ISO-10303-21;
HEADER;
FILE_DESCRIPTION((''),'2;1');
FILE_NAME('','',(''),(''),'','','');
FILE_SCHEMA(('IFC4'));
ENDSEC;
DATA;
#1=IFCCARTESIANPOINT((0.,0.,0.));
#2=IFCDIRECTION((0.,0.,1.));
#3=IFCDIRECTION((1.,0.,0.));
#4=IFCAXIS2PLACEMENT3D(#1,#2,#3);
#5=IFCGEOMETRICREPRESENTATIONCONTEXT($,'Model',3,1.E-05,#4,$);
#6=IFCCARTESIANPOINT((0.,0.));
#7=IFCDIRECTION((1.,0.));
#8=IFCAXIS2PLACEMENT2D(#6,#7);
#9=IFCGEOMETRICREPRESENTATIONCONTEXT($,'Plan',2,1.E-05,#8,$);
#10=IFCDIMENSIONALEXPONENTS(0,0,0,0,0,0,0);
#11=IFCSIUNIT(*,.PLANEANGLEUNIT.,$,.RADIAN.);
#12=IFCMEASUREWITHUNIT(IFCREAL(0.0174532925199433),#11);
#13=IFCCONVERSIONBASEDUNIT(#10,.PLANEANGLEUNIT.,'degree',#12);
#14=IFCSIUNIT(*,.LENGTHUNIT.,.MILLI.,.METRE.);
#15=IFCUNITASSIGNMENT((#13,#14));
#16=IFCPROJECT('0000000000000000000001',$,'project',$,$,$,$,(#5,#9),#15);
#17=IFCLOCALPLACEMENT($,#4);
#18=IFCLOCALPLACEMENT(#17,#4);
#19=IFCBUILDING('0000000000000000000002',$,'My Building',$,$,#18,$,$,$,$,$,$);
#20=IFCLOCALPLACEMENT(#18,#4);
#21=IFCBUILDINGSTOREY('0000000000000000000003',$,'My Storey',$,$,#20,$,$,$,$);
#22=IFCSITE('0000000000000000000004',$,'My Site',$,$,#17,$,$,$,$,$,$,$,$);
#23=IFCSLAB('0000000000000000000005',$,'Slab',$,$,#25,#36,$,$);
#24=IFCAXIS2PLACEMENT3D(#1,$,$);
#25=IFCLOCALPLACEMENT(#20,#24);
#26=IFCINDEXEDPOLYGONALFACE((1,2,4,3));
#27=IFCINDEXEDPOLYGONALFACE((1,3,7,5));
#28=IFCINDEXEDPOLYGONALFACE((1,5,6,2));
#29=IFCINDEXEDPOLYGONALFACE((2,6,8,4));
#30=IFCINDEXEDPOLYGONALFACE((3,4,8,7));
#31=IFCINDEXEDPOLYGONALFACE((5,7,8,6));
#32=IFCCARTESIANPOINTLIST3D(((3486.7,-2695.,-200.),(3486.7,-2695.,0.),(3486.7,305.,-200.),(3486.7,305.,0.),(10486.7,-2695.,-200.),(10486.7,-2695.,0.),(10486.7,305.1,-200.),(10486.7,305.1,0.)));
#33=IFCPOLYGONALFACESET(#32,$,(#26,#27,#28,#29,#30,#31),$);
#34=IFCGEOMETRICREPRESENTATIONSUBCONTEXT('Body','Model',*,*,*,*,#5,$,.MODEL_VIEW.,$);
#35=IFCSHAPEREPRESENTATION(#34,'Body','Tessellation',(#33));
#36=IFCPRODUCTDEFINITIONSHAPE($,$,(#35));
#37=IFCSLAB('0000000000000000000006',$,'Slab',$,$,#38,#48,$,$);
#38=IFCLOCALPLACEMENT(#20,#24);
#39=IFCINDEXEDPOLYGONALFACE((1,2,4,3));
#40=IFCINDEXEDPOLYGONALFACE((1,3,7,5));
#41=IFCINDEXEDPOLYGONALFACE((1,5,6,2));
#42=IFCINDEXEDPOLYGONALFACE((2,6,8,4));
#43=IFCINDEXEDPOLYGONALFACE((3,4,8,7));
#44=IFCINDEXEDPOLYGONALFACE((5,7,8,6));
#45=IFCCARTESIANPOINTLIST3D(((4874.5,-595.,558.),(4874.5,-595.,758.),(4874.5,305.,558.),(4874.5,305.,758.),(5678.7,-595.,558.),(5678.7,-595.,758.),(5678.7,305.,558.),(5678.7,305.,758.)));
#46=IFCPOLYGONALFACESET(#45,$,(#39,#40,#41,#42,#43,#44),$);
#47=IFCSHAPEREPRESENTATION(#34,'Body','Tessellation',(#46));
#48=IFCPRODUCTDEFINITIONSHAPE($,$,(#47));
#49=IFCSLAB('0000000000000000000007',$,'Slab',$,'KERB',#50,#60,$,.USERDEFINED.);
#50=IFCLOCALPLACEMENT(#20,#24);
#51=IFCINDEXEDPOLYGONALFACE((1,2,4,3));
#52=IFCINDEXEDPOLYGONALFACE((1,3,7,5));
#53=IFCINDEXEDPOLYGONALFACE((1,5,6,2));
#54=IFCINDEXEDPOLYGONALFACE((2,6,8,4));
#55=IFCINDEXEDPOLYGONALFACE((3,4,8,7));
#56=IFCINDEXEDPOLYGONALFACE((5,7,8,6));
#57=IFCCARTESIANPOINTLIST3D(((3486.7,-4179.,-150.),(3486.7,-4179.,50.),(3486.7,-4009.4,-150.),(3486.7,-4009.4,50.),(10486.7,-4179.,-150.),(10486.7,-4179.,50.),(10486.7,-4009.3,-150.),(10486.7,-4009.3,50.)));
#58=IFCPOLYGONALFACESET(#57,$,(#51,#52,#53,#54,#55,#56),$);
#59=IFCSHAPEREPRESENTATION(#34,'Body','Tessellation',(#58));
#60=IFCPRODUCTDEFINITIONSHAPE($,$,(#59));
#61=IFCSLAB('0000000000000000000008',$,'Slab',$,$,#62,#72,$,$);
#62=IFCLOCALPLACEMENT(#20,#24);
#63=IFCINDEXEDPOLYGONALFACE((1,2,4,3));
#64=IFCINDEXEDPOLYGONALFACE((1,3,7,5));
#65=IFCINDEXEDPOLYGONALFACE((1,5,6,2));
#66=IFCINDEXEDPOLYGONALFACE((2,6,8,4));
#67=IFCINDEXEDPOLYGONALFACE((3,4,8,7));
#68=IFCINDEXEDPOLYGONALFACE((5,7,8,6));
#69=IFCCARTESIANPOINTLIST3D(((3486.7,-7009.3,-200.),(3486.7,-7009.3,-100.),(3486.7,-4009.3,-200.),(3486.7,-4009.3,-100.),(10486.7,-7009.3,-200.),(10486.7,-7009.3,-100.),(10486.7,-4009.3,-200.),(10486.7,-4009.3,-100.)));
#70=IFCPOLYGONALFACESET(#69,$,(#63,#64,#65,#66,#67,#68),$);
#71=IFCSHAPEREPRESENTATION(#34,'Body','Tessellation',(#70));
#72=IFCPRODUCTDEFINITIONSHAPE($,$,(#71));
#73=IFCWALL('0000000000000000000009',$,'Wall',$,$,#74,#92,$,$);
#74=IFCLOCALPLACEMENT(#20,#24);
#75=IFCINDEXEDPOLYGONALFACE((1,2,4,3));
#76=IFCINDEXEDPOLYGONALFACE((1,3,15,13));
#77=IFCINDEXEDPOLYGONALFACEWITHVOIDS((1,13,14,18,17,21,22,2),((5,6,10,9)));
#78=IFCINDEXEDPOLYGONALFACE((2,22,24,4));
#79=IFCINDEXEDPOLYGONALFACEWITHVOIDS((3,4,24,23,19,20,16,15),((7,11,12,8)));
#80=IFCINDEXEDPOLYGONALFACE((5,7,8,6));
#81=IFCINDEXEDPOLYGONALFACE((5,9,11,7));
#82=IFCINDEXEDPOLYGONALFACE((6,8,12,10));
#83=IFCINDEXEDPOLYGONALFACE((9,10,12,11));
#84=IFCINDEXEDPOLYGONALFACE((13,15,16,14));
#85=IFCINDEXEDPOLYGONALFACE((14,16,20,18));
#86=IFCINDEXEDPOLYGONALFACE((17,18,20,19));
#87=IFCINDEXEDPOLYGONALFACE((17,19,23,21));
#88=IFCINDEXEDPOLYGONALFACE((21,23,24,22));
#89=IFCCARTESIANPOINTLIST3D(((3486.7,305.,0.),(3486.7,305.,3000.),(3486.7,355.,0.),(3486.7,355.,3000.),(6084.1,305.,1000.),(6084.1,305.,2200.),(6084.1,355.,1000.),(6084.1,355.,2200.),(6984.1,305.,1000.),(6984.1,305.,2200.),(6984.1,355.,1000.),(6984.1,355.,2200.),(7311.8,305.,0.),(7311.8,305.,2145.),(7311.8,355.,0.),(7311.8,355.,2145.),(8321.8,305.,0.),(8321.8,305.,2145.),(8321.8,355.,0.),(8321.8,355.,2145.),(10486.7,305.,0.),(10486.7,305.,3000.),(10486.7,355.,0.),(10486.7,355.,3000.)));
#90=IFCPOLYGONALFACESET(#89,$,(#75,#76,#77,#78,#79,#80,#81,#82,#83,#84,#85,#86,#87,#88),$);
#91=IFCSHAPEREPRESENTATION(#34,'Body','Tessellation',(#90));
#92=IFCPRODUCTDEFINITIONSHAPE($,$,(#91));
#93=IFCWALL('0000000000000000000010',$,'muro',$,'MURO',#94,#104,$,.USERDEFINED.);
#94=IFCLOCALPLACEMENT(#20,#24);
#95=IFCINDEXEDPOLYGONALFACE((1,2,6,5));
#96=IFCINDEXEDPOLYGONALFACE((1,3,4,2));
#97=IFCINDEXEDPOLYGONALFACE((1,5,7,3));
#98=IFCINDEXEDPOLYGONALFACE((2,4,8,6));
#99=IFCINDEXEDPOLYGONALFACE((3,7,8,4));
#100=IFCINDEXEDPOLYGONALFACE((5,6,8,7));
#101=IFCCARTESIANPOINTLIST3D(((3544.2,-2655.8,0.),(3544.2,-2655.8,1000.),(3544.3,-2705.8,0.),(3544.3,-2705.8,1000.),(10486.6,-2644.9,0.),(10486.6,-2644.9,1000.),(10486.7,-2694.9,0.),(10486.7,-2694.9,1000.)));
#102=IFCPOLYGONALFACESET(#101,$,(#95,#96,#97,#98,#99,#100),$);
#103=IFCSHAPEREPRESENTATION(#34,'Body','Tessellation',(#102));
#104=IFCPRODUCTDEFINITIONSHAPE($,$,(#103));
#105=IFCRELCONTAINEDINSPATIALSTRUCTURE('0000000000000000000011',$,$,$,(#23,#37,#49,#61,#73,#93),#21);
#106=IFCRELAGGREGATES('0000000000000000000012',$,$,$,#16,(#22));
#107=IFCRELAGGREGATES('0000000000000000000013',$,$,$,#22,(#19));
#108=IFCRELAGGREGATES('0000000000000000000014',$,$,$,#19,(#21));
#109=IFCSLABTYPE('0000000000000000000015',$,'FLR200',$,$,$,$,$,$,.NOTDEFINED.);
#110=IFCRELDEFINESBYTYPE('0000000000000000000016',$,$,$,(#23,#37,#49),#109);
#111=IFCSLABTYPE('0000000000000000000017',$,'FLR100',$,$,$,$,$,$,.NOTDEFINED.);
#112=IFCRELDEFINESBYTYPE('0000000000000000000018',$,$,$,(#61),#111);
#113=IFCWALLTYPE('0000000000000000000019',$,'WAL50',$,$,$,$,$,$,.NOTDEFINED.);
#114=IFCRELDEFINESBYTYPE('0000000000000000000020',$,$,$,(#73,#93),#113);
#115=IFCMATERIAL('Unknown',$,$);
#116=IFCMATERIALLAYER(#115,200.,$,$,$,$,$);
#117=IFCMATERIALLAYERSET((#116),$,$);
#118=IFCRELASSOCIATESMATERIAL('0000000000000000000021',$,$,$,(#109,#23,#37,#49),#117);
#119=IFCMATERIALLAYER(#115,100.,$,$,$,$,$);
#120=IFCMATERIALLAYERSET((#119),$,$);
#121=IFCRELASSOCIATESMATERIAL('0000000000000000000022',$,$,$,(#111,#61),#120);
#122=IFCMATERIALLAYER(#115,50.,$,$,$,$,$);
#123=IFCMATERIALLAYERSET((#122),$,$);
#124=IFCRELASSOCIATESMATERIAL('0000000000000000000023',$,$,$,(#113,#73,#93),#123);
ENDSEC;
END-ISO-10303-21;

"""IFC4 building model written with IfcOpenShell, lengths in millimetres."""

from ifc_helpers import new_model, entity, si_unit, converted_unit, frame, origin_with_axes, origin_2d_with_axis, place, context, subcontext, project, spatial, line, indexed_curve, outline, extrude, source, transform, mapped, material, layer, layer_set, layer_usage, type_object, element, save


model = new_model("IFC4")

# Units and contexts
model_context = context("Model", 3, precision=1e-05, world=origin_with_axes())
plan_context = context("Plan", 2, precision=1e-05, world=origin_2d_with_axis())
body_context = subcontext(model_context, "Body", "Model", "MODEL_VIEW")
ifc_project = project(units=[converted_unit("PLANEANGLEUNIT", "degree", entity("IfcReal", 0.0174532925199433), si_unit("PLANEANGLEUNIT", "RADIAN"), dimensions=[0, 0, 0, 0, 0, 0, 0]), si_unit("LENGTHUNIT", "METRE", prefix="MILLI")], contexts=[model_context, plan_context])

# Site, building, storey
site_placement = place(None, origin_with_axes())
site = spatial("IfcSite", under=ifc_project, at=site_placement, Name="My Site")
building_placement = place(site_placement, origin_with_axes())
building = spatial("IfcBuilding", under=site, at=building_placement, Name="My Building")
storey_placement = place(building_placement, origin_with_axes())
storey = spatial("IfcBuildingStorey", under=building, at=storey_placement, Name="My Storey")

# Slabs
ifc_material = material(Name="Unknown")
ifc_layer_1 = layer(ifc_material, 200.0)
ifc_layer_set_1 = layer_set([ifc_layer_1])
ifc_layer_usage_1 = layer_usage(ifc_layer_set_1, "AXIS3", "POSITIVE", -200.0)
slab_type_1 = type_object("IfcSlabType", Name="FLR200", PredefinedType="NOTDEFINED", material=ifc_layer_set_1)
slab_1_placement = place(storey_placement, frame((3486.7, 305.0, 0.0), z_axis=(0.0, 0.0, 1.0), x_axis=(1.0, 0.0, 0.0)))
element("IfcSlab", 1, at=slab_1_placement, inside=storey, type_object=slab_type_1, material=ifc_layer_usage_1, Name="Slab", context=body_context, shape_type="SweptSolid", body=[
    extrude(outline(indexed_curve([(0.0, 0.0), (0.0, -3000.0), (7000.0, -3000.0), (7000.0, 0.0), (0.0, 0.0)])), frame((0.0, 0.0, -200.0), z_axis=(0.0, 0.0, 1.0), x_axis=(1.0, 0.0, 0.0)), (0.0, 0.0, 1.0), 200.0),
])
ifc_layer_usage_2 = layer_usage(ifc_layer_set_1, "AXIS3", "POSITIVE", -200.0)
slab_2_placement = place(storey_placement, frame((4874.5, -595.0, 758.0), z_axis=(0.0, 0.0, 1.0), x_axis=(1.0, 0.0, 0.0)))
element("IfcSlab", 2, at=slab_2_placement, inside=storey, type_object=slab_type_1, material=ifc_layer_usage_2, Name="Slab", context=body_context, shape_type="SweptSolid", body=[
    extrude(outline(indexed_curve([(0.0, 0.0), (804.2, 0.0), (804.2, 900.0), (0.0, 900.0), (0.0, 0.0)])), frame((0.0, 0.0, -200.0), z_axis=(0.0, 0.0, 1.0), x_axis=(1.0, 0.0, 0.0)), (0.0, 0.0, 1.0), 200.0),
])
ifc_layer_usage_3 = layer_usage(ifc_layer_set_1, "AXIS3", "POSITIVE", -200.0)
slab_3_placement = place(storey_placement, frame((3486.7, -4009.4, 50.0), z_axis=(0.0, 0.0, 1.0), x_axis=(1.0, 0.0, 0.0)))
element("IfcSlab", 3, at=slab_3_placement, inside=storey, type_object=slab_type_1, material=ifc_layer_usage_3, Name="Slab", ObjectType="KERB", PredefinedType="USERDEFINED", context=body_context, shape_type="SweptSolid", body=[
    extrude(outline(indexed_curve([(7000.0, 0.0), (7000.0, -169.6), (0.0, -169.6), (0.0, 0.0), (7000.0, 0.0)])), frame((0.0, 0.0, -200.0), z_axis=(0.0, 0.0, 1.0), x_axis=(1.0, 0.0, 0.0)), (0.0, 0.0, 1.0), 200.0),
])
ifc_layer_2 = layer(ifc_material, 100.0)
ifc_layer_set_2 = layer_set([ifc_layer_2])
ifc_layer_usage_4 = layer_usage(ifc_layer_set_2, "AXIS3", "POSITIVE", 0.0)
slab_type_2 = type_object("IfcSlabType", Name="FLR100", PredefinedType="NOTDEFINED", material=ifc_layer_set_2)
slab_4_placement = place(storey_placement, frame((3486.7, -4009.3, -200.0), z_axis=(0.0, 0.0, 1.0), x_axis=(1.0, 0.0, 0.0)))
element("IfcSlab", 4, at=slab_4_placement, inside=storey, type_object=slab_type_2, material=ifc_layer_usage_4, Name="Slab", context=body_context, shape_type="SweptSolid", body=[
    extrude(outline(indexed_curve([(0.0, 0.0), (0.0, -3000.0), (7000.0, -3000.0), (7000.0, 0.0), (0.0, 0.0)])), origin_with_axes(), (0.0, 0.0, 1.0), 100.0),
])

# Wall, openings
ifc_layer_3 = layer(ifc_material, 50.0)
ifc_layer_set_3 = layer_set([ifc_layer_3])
ifc_layer_usage_5 = layer_usage(ifc_layer_set_3, "AXIS2", "POSITIVE", 0.0)
wall_type = type_object("IfcWallType", Name="WAL50", PredefinedType="NOTDEFINED", material=ifc_layer_set_3)
wall_1_placement = place(storey_placement, frame((3486.7, 305.0, 0.0), z_axis=(0.0, 0.0, 1.0), x_axis=(1.0, 0.0, 0.0)))
wall_1 = element("IfcWall", 5, at=wall_1_placement, inside=storey, type_object=wall_type, material=ifc_layer_usage_5, Name="Wall", context=body_context, shape_type="SweptSolid", body=[
    extrude(outline(indexed_curve([(0.0, 0.0), (0.0, 50.0), (7000.0, 50.0), (7000.0, 0.0)], segments=[line(1, 2, 3, 4, 1)])), origin_with_axes(), (0.0, 0.0, 1.0), 3000.0),
])
shared_shape_1 = source(origin_with_axes(), body_context, "Body", "SweptSolid", [
    extrude(outline(indexed_curve([(0.0, 0.0), (1010.0, 0.0), (1010.0, 2145.0), (0.0, 2145.0)], segments=[line(1, 2, 3, 4, 1)])), frame((0.0, -600.0, 0.0), z_axis=(0.0, -1.0, 0.0), x_axis=(1.0, 0.0, 0.0)), (0.0, 0.0, -1.0), 1200.0),
])
opening_1_placement = place(wall_1_placement, frame((3825.1, 0.0, 0.0), z_axis=(0.0, 0.0, 1.0), x_axis=(1.0, 0.0, 0.0)))
element("IfcOpeningElement", 6, at=opening_1_placement, cuts=wall_1, PredefinedType="OPENING", context=body_context, shape_type="MappedRepresentation", body=[
    mapped(shared_shape_1, transform((0.0, 0.0, 0.0), x_axis=(1.0, 0.0, 0.0), y_axis=(0.0, 1.0, 0.0), z_axis=(0.0, 0.0, 1.0), scale=1.0)),
])
shared_shape_2 = source(origin_with_axes(), body_context, "Body", "SweptSolid", [
    extrude(outline(indexed_curve([(0.0, 0.0), (900.0, 0.0), (900.0, 1200.0), (0.0, 1200.0)], segments=[line(1, 2, 3, 4, 1)])), frame((0.0, -600.0, 0.0), z_axis=(0.0, -1.0, 0.0), x_axis=(1.0, 0.0, 0.0)), (0.0, 0.0, -1.0), 1200.0),
])
opening_2_placement = place(wall_1_placement, frame((2597.4, 0.0, 1000.0), z_axis=(0.0, 0.0, 1.0), x_axis=(1.0, 0.0, 0.0)))
element("IfcOpeningElement", 7, at=opening_2_placement, cuts=wall_1, PredefinedType="OPENING", context=body_context, shape_type="MappedRepresentation", body=[
    mapped(shared_shape_2, transform((0.0, 0.0, 0.0), x_axis=(1.0, 0.0, 0.0), y_axis=(0.0, 1.0, 0.0), z_axis=(0.0, 0.0, 1.0), scale=1.0)),
])

# Wall
ifc_layer_usage_6 = layer_usage(ifc_layer_set_3, "AXIS2", "POSITIVE", 0.0)
wall_2_placement = place(storey_placement, frame((3544.3, -2705.8, 0.0), z_axis=(0.0, 0.0, 1.0), x_axis=(0.999999, 0.001559, 0.0)))
element("IfcWall", 8, at=wall_2_placement, inside=storey, type_object=wall_type, material=ifc_layer_usage_6, Name="muro", ObjectType="MURO", PredefinedType="USERDEFINED", context=body_context, shape_type="SweptSolid", body=[
    extrude(outline(indexed_curve([(0.0, 0.0), (0.0, 50.0), (6942.4, 50.0), (6942.4, 0.0)], segments=[line(1, 2, 3, 4, 1)])), origin_with_axes(), (0.0, 0.0, 1.0), 1000.0),
])

save(model, "model.ifc")
